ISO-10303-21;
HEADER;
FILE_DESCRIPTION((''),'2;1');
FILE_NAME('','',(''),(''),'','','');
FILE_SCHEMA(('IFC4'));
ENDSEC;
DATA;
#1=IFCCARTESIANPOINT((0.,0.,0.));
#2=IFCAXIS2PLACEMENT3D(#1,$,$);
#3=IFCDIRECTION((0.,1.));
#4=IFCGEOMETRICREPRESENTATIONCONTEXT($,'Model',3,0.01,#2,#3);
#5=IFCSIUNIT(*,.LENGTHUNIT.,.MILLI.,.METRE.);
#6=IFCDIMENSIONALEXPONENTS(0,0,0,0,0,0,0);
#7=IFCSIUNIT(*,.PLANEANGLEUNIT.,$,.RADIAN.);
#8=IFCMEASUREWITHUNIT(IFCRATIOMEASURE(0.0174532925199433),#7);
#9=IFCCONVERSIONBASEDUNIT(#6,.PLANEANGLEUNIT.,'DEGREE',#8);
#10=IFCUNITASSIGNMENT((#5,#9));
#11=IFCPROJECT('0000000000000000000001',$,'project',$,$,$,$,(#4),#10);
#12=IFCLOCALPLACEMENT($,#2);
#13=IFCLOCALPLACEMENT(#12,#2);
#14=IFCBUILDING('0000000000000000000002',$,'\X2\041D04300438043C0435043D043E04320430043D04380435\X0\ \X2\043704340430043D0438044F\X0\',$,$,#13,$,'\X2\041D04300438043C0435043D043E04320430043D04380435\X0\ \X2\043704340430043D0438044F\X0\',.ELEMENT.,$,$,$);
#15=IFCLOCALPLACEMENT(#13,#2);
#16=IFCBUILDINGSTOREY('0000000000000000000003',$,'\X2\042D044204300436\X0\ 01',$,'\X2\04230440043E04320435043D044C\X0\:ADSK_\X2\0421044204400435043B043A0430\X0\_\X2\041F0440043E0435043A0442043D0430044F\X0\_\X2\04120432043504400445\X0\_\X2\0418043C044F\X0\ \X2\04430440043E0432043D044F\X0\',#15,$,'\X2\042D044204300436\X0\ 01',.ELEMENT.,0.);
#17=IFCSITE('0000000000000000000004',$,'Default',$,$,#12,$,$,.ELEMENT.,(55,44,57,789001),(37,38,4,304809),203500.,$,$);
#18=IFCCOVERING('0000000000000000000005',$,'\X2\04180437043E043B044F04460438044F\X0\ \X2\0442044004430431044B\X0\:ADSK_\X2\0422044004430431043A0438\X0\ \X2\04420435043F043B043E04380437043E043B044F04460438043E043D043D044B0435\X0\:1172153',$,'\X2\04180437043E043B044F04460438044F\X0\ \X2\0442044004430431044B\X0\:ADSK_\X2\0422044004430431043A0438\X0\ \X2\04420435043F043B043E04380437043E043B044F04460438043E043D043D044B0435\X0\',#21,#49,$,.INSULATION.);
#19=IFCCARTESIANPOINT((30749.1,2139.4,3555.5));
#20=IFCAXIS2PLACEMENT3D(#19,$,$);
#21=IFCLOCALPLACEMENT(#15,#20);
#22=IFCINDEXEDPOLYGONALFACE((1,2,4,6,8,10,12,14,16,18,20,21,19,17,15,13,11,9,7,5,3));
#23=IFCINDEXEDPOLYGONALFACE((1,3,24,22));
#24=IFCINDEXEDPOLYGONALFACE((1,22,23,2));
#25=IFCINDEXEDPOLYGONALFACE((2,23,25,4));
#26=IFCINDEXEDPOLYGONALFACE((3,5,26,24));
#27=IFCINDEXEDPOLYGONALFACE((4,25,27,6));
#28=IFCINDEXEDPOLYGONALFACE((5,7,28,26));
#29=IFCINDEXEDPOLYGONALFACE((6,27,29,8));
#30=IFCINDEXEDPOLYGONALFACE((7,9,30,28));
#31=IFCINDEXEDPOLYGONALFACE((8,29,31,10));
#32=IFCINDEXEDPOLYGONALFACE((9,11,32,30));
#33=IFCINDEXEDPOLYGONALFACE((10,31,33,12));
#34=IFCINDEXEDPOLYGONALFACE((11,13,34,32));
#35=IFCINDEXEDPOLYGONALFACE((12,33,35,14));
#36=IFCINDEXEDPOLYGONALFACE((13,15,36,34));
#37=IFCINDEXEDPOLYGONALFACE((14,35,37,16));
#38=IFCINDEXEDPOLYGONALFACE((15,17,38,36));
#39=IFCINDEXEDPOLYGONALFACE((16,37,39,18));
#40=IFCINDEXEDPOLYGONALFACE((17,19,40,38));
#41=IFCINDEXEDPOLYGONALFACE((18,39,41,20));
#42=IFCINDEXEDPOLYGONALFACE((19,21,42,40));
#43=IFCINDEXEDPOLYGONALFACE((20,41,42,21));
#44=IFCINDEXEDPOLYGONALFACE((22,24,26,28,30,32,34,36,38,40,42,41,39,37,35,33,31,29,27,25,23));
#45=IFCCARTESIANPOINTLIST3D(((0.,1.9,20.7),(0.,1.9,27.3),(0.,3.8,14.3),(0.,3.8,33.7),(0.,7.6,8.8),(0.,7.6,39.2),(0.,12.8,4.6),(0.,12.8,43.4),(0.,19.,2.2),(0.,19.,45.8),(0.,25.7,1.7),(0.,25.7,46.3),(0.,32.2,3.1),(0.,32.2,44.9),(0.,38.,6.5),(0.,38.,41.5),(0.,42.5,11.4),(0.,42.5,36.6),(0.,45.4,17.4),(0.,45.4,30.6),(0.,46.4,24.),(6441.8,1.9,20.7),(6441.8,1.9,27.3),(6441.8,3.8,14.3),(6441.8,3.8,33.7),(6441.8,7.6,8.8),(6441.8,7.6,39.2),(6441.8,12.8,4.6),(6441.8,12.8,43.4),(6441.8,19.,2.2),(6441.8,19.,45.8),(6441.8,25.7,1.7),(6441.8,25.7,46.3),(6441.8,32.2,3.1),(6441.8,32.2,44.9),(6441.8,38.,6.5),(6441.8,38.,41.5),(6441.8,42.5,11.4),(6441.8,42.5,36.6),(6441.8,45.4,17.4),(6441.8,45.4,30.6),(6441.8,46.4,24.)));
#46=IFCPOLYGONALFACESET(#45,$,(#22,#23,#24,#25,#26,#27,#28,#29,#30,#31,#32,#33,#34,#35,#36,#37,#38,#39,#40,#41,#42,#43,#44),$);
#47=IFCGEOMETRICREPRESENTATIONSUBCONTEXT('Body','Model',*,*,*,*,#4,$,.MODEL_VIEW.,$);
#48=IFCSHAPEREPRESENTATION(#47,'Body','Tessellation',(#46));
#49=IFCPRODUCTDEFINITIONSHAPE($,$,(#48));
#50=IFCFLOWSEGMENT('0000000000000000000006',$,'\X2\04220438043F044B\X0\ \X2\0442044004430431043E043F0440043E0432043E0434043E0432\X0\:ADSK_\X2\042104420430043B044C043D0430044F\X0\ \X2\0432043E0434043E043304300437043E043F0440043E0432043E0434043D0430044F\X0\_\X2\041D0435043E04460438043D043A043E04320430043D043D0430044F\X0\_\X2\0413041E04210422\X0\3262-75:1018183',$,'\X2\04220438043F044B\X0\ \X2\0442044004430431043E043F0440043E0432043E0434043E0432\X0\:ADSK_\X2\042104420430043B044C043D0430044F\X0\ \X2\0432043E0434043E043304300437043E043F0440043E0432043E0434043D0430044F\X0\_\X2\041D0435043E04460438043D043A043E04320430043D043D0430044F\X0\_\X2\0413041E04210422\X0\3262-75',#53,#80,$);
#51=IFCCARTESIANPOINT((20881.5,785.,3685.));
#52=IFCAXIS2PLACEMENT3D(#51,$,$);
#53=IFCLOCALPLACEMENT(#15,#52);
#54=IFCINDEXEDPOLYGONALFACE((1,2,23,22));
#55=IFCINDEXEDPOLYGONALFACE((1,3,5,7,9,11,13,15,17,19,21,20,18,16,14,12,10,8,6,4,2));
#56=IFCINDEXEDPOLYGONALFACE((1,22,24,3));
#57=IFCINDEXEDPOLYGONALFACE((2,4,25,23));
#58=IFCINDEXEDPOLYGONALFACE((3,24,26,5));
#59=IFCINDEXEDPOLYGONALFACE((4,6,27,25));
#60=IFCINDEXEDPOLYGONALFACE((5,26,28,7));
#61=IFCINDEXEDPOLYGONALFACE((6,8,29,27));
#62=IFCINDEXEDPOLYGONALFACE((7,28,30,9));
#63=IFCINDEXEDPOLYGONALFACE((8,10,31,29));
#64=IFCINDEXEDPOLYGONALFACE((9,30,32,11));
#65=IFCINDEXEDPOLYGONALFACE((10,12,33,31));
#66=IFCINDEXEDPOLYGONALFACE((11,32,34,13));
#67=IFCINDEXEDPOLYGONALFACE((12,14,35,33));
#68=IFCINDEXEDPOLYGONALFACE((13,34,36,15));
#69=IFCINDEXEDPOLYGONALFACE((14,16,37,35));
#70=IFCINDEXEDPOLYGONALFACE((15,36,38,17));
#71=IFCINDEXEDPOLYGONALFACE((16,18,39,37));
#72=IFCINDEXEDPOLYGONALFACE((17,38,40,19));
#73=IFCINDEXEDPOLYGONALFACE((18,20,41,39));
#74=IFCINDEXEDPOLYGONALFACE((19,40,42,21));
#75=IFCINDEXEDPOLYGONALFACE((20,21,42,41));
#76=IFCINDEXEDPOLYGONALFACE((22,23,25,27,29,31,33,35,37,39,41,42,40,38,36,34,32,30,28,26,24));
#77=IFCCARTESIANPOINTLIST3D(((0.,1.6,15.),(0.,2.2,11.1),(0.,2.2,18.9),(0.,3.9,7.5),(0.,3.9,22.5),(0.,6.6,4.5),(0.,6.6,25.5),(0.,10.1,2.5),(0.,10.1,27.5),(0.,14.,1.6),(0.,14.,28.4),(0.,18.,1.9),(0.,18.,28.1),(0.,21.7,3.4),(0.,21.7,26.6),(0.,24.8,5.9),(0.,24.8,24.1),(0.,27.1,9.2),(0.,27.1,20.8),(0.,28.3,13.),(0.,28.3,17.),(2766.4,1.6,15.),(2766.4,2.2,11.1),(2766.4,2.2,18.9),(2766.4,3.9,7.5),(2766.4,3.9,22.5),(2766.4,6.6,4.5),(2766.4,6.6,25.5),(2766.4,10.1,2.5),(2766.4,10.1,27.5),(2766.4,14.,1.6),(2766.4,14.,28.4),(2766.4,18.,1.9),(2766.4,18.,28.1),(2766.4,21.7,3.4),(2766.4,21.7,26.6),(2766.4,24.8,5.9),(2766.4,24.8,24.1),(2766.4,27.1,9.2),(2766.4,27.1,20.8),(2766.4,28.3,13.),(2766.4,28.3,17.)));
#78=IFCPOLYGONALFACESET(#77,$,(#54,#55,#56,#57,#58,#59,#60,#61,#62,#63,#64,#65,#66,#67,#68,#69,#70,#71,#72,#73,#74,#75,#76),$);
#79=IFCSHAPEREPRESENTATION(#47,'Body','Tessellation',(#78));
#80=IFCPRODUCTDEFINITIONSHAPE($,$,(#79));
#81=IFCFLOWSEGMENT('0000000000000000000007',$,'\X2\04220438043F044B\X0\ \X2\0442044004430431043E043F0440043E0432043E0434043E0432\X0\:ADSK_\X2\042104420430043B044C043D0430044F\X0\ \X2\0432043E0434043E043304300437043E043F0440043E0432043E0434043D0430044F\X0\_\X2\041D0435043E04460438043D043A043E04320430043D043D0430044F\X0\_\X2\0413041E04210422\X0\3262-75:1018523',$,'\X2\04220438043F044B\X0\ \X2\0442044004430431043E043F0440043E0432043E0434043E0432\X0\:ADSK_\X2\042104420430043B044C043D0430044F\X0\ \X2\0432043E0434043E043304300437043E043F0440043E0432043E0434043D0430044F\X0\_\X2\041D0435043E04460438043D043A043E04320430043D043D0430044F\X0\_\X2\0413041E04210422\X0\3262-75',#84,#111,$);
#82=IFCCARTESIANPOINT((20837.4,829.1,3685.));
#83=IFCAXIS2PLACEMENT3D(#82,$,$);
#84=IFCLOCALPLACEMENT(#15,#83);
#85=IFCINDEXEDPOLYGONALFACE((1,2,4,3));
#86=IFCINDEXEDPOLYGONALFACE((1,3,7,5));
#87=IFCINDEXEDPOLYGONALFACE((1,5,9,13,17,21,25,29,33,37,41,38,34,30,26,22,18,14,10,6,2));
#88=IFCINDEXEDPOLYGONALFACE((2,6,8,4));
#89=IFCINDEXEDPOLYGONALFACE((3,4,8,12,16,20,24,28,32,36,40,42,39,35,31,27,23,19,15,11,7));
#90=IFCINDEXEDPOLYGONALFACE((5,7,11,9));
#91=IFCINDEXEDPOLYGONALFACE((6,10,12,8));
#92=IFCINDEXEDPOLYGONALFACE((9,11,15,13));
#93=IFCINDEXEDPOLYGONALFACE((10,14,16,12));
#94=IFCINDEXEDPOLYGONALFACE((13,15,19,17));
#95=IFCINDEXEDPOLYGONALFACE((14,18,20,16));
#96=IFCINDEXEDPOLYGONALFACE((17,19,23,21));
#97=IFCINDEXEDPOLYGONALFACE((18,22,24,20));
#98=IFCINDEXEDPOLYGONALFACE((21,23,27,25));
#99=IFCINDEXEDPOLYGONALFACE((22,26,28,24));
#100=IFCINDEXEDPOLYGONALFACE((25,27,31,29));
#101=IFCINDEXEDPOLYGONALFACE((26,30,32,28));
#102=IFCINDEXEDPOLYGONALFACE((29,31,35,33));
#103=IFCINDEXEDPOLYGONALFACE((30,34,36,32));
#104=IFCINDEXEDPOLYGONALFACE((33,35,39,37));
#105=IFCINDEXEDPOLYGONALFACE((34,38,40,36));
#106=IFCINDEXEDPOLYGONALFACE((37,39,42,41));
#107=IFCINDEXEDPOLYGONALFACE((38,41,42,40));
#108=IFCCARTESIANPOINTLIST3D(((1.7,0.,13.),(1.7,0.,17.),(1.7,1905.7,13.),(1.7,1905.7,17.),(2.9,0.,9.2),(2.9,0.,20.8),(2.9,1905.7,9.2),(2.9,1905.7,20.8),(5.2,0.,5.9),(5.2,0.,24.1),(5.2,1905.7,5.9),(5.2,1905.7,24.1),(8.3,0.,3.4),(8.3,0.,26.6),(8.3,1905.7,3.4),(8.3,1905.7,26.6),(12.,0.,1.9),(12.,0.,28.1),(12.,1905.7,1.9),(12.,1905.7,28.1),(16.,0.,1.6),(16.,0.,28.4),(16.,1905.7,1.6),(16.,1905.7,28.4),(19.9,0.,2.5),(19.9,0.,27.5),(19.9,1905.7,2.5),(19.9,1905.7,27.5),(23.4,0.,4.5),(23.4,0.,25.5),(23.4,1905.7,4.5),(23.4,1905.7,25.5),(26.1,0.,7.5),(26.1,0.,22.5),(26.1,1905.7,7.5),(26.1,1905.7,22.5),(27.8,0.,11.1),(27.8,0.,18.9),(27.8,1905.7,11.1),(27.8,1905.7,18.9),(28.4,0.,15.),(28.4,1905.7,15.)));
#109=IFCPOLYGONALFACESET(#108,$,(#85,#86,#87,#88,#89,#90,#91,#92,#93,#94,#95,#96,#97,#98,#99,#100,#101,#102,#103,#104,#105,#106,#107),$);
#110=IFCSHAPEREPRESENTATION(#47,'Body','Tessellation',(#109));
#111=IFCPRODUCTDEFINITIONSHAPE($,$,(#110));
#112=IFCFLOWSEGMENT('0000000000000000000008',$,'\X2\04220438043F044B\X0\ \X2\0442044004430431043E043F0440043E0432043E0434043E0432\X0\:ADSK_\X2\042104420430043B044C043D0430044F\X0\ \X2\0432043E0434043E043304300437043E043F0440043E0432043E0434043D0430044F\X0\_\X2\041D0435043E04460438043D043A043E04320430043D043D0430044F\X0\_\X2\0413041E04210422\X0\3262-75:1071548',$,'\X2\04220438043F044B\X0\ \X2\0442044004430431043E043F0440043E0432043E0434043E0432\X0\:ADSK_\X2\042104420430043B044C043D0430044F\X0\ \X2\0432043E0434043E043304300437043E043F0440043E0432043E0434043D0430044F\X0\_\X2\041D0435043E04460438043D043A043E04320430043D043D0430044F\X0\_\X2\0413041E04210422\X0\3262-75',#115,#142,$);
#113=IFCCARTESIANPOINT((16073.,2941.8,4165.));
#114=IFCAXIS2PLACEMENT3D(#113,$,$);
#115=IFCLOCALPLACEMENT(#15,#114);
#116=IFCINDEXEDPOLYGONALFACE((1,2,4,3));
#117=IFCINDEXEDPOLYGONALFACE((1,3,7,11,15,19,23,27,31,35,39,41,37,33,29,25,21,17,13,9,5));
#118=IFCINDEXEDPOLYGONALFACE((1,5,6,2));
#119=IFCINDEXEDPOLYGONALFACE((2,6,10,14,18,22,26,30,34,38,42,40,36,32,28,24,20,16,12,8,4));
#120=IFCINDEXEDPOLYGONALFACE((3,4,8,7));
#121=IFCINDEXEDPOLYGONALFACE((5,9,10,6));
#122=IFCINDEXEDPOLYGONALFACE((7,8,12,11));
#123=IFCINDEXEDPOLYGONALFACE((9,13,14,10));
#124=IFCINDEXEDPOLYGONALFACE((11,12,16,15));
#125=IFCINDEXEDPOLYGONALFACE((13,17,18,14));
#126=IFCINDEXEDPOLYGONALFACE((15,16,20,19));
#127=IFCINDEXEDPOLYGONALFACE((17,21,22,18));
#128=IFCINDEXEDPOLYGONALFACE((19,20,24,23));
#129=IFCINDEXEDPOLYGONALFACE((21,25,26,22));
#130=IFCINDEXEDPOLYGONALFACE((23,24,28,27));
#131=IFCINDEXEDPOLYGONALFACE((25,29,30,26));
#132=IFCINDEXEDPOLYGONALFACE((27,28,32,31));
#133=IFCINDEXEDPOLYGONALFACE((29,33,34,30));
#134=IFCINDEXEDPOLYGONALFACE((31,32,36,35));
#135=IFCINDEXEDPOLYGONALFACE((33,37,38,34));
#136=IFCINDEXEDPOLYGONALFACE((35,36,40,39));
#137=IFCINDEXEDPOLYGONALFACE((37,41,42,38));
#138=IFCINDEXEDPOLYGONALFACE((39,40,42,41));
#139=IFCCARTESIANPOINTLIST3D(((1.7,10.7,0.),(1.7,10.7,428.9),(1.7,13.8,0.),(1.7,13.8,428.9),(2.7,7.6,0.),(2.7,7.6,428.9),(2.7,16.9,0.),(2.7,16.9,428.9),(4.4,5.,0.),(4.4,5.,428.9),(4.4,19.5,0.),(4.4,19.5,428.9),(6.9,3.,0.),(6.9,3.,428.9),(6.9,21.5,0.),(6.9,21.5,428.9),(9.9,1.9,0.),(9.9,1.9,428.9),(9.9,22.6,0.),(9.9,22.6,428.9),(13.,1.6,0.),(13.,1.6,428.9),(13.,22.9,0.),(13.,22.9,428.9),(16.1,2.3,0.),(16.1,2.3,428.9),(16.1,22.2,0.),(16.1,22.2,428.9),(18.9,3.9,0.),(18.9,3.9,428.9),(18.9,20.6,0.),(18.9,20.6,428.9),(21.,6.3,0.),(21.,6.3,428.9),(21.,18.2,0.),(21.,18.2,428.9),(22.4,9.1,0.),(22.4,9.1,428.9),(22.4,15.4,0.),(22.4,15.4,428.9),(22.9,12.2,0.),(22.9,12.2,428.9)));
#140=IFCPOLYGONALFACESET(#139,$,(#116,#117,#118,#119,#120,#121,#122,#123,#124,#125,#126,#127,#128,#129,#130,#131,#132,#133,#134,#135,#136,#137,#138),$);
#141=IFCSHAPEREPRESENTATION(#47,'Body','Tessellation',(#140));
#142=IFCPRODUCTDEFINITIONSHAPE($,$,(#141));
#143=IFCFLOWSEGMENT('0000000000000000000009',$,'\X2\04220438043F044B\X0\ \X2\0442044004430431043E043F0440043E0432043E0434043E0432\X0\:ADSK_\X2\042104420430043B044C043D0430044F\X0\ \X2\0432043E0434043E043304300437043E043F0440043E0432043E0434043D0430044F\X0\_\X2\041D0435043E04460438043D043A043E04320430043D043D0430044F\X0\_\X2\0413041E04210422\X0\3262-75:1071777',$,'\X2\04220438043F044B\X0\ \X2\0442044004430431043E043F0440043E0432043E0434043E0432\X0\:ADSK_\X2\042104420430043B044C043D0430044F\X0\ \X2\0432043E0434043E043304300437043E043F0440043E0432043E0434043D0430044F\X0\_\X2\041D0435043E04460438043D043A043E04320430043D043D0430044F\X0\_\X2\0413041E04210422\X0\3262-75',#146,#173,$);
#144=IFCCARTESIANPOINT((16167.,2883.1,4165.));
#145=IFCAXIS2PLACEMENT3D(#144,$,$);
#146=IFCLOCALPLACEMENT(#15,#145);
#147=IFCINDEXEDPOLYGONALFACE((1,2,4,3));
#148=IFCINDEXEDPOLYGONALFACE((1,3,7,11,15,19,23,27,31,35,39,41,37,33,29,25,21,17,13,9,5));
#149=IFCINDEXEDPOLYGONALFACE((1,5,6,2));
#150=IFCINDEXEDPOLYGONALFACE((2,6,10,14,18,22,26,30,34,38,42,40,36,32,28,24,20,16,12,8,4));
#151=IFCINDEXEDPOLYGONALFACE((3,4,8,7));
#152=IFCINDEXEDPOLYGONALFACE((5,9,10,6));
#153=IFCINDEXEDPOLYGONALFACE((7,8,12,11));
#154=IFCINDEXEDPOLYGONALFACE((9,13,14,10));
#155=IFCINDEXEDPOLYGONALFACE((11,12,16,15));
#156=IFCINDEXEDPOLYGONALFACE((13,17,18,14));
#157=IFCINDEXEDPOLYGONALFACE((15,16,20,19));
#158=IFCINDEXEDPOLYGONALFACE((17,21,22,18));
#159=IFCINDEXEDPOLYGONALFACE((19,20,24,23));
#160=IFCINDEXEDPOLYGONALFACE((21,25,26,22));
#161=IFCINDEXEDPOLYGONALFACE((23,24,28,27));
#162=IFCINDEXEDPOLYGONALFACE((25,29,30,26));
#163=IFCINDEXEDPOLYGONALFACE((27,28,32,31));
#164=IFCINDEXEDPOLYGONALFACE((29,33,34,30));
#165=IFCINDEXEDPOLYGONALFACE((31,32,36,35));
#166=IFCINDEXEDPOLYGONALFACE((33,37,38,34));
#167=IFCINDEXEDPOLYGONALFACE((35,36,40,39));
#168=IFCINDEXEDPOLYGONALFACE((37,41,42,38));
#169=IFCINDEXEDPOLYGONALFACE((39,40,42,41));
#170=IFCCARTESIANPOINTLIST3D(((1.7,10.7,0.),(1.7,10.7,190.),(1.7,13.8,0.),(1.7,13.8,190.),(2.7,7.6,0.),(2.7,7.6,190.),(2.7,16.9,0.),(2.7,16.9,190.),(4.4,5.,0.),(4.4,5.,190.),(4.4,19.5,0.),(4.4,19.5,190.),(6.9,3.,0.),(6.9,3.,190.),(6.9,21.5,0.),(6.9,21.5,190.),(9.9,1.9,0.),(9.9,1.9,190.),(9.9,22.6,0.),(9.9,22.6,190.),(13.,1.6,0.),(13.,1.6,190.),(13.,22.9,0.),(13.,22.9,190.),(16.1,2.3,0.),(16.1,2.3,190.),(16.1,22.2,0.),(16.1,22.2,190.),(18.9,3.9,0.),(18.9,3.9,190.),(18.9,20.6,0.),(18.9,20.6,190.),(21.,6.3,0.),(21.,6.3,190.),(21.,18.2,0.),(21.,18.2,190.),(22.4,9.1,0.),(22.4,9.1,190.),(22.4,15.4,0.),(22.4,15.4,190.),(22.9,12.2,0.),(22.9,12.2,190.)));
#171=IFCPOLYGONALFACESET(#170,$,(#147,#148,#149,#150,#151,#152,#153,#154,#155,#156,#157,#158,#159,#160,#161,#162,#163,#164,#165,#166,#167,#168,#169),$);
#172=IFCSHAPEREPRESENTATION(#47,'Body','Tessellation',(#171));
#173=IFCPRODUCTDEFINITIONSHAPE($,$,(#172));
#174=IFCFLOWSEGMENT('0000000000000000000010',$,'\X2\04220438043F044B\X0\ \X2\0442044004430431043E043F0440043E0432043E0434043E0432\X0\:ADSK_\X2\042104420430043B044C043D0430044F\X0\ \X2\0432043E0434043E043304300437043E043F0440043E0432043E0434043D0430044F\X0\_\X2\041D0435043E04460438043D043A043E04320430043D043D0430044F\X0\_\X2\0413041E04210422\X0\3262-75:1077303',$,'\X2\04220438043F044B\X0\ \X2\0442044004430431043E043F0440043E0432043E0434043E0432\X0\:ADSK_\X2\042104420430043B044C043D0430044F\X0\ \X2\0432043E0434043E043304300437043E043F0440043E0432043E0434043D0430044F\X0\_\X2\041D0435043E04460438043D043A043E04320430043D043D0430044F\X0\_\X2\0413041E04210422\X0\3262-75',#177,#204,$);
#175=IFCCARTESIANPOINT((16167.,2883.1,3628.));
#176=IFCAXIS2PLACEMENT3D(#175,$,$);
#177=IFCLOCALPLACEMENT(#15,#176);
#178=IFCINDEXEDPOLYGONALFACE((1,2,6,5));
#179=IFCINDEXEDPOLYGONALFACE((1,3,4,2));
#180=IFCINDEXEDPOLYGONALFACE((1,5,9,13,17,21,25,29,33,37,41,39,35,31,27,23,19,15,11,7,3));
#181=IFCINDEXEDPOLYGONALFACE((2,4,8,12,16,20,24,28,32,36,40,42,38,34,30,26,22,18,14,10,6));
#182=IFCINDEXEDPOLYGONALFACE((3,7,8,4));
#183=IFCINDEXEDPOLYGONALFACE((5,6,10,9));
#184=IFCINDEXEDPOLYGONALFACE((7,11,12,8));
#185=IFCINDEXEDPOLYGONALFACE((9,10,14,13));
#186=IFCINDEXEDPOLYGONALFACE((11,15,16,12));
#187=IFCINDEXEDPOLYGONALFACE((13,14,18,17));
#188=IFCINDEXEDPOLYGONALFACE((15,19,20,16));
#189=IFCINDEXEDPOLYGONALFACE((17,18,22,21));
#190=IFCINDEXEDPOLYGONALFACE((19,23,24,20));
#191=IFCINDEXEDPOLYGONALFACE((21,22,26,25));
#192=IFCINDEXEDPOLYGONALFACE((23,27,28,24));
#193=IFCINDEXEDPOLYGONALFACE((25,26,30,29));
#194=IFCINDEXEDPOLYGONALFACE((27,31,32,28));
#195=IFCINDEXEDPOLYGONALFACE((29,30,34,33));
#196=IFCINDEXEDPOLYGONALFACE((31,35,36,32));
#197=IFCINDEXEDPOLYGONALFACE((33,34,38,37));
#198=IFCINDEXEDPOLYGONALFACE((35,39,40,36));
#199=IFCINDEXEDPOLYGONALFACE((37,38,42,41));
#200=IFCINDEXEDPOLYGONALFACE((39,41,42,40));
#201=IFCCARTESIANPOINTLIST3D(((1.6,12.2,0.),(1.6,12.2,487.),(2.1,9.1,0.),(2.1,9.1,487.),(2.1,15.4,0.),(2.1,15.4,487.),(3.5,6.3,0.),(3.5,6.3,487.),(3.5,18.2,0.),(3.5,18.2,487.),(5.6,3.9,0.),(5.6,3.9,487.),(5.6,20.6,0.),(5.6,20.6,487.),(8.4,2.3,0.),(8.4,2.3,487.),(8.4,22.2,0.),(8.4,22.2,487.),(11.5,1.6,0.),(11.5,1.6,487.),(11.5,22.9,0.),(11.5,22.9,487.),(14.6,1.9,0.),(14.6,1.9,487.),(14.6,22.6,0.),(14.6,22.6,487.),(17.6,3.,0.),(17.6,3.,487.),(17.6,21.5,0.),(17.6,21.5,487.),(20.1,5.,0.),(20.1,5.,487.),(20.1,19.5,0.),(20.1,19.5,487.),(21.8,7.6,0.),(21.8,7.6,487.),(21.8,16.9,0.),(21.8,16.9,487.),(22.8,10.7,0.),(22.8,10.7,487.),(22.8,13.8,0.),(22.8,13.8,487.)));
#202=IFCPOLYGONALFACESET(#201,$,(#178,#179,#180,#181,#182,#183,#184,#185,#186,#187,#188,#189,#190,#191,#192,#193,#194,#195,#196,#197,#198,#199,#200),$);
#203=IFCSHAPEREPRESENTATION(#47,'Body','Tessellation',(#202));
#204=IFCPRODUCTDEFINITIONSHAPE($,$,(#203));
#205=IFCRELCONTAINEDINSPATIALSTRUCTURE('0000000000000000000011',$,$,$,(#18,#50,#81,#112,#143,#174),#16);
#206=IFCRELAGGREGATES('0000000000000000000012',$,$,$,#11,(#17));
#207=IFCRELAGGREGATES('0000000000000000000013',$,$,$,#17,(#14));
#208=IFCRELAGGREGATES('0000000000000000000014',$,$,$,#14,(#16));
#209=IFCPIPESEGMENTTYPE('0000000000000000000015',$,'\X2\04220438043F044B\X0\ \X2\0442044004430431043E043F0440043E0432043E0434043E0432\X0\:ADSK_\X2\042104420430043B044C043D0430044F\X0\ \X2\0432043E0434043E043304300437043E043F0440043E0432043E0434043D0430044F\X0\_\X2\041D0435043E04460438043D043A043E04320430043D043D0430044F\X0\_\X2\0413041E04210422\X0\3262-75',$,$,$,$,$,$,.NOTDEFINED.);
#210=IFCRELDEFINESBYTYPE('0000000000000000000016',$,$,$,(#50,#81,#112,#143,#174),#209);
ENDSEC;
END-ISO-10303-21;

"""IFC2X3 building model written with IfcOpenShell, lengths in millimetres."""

from ifc_helpers import new_model, entity, si_unit, converted_unit, direction, frame, origin, origin_2d_with_axis, place, context, subcontext, project, spatial, circle, extrude, type_object, element, save


model = new_model("IFC2X3")

# Units and contexts
model_context = context("Model", 3, precision=0.01, world=origin(), true_north=direction((0.0, 1.0)))
body_context = subcontext(model_context, "Body", "Model", "MODEL_VIEW")
ifc_project = project(units=[si_unit("LENGTHUNIT", "METRE", prefix="MILLI"), converted_unit("PLANEANGLEUNIT", "DEGREE", entity("IfcRatioMeasure", 0.0174532925199433), si_unit("PLANEANGLEUNIT", "RADIAN"), dimensions=[0, 0, 0, 0, 0, 0, 0])], contexts=[model_context])

# Site, building, storey
site_placement = place(None, origin())
site = spatial("IfcSite", under=ifc_project, at=site_placement, Name="Default", CompositionType="ELEMENT", RefLatitude=(55, 44, 57, 789001), RefLongitude=(37, 38, 4, 304809), RefElevation=203500.0)
building_placement = place(site_placement, origin())
building = spatial("IfcBuilding", under=site, at=building_placement, Name="Наименование здания", LongName="Наименование здания", CompositionType="ELEMENT")
storey_placement = place(building_placement, origin())
storey = spatial("IfcBuildingStorey", under=building, at=storey_placement, Name="Этаж 01", ObjectType="Уровень:ADSK_Стрелка_Проектная_Вверх_Имя уровня", LongName="Этаж 01", CompositionType="ELEMENT", Elevation=0.0)

# Covering
covering_placement = place(storey_placement, frame((30749.1, 2139.4, 3555.5)))
element("IfcCovering", 1, at=covering_placement, inside=storey, Name="Изоляция трубы:ADSK_Трубки теплоизоляционные:1172153", ObjectType="Изоляция трубы:ADSK_Трубки теплоизоляционные", PredefinedType="INSULATION", context=body_context, shape_type="SweptSolid", body=[
    extrude(circle(Radius=22.4, at=origin_2d_with_axis()), frame((0.0, 24.0, 24.0), z_axis=(1.0, 0.0, 0.0), x_axis=(0.0, 1.0, 0.0)), (0.0, 0.0, 1.0), 6441.8),
])

# Flow segments
pipe_segment_type = type_object("IfcPipeSegmentType", Name="Типы трубопроводов:ADSK_Стальная водогазопроводная_Неоцинкованная_ГОСТ3262-75", PredefinedType="NOTDEFINED")
flow_segment_1_placement = place(storey_placement, frame((20881.5, 785.0, 3685.0)))
element("IfcFlowSegment", 2, at=flow_segment_1_placement, inside=storey, type_object=pipe_segment_type, Name="Типы трубопроводов:ADSK_Стальная водогазопроводная_Неоцинкованная_ГОСТ3262-75:1018183", ObjectType="Типы трубопроводов:ADSK_Стальная водогазопроводная_Неоцинкованная_ГОСТ3262-75", context=body_context, shape_type="SweptSolid", body=[
    extrude(circle(Radius=13.4, at=origin_2d_with_axis()), frame((0.0, 15.0, 15.0), z_axis=(1.0, 0.0, 0.0), x_axis=(0.0, -1.0, 0.0)), (0.0, 0.0, 1.0), 2766.4),
])
flow_segment_2_placement = place(storey_placement, frame((20837.4, 829.1, 3685.0)))
element("IfcFlowSegment", 3, at=flow_segment_2_placement, inside=storey, type_object=pipe_segment_type, Name="Типы трубопроводов:ADSK_Стальная водогазопроводная_Неоцинкованная_ГОСТ3262-75:1018523", ObjectType="Типы трубопроводов:ADSK_Стальная водогазопроводная_Неоцинкованная_ГОСТ3262-75", context=body_context, shape_type="SweptSolid", body=[
    extrude(circle(Radius=13.4, at=origin_2d_with_axis()), frame((15.0, 0.0, 15.0), z_axis=(0.0, 1.0, 0.0), x_axis=(1.0, 0.0, 0.0)), (0.0, 0.0, 1.0), 1905.7),
])
flow_segment_3_placement = place(storey_placement, frame((16073.0, 2941.8, 4165.0)))
element("IfcFlowSegment", 4, at=flow_segment_3_placement, inside=storey, type_object=pipe_segment_type, Name="Типы трубопроводов:ADSK_Стальная водогазопроводная_Неоцинкованная_ГОСТ3262-75:1071548", ObjectType="Типы трубопроводов:ADSK_Стальная водогазопроводная_Неоцинкованная_ГОСТ3262-75", context=body_context, shape_type="SweptSolid", body=[
    extrude(circle(Radius=10.7, at=origin_2d_with_axis()), frame((12.2, 12.2, 0.0)), (0.0, 0.0, 1.0), 428.9),
])
flow_segment_4_placement = place(storey_placement, frame((16167.0, 2883.1, 4165.0)))
element("IfcFlowSegment", 5, at=flow_segment_4_placement, inside=storey, type_object=pipe_segment_type, Name="Типы трубопроводов:ADSK_Стальная водогазопроводная_Неоцинкованная_ГОСТ3262-75:1071777", ObjectType="Типы трубопроводов:ADSK_Стальная водогазопроводная_Неоцинкованная_ГОСТ3262-75", context=body_context, shape_type="SweptSolid", body=[
    extrude(circle(Radius=10.7, at=origin_2d_with_axis()), frame((12.2, 12.2, 0.0)), (0.0, 0.0, 1.0), 190.0),
])
flow_segment_5_placement = place(storey_placement, frame((16167.0, 2883.1, 3628.0)))
element("IfcFlowSegment", 6, at=flow_segment_5_placement, inside=storey, type_object=pipe_segment_type, Name="Типы трубопроводов:ADSK_Стальная водогазопроводная_Неоцинкованная_ГОСТ3262-75:1077303", ObjectType="Типы трубопроводов:ADSK_Стальная водогазопроводная_Неоцинкованная_ГОСТ3262-75", context=body_context, shape_type="SweptSolid", body=[
    extrude(circle(Radius=10.7, at=origin_2d_with_axis()), frame((12.2, 12.2, 0.0), z_axis=(0.0, 0.0, 1.0), x_axis=(-1.0, 0.0, 0.0)), (0.0, 0.0, 1.0), 487.0),
])

save(model, "model.ifc")
